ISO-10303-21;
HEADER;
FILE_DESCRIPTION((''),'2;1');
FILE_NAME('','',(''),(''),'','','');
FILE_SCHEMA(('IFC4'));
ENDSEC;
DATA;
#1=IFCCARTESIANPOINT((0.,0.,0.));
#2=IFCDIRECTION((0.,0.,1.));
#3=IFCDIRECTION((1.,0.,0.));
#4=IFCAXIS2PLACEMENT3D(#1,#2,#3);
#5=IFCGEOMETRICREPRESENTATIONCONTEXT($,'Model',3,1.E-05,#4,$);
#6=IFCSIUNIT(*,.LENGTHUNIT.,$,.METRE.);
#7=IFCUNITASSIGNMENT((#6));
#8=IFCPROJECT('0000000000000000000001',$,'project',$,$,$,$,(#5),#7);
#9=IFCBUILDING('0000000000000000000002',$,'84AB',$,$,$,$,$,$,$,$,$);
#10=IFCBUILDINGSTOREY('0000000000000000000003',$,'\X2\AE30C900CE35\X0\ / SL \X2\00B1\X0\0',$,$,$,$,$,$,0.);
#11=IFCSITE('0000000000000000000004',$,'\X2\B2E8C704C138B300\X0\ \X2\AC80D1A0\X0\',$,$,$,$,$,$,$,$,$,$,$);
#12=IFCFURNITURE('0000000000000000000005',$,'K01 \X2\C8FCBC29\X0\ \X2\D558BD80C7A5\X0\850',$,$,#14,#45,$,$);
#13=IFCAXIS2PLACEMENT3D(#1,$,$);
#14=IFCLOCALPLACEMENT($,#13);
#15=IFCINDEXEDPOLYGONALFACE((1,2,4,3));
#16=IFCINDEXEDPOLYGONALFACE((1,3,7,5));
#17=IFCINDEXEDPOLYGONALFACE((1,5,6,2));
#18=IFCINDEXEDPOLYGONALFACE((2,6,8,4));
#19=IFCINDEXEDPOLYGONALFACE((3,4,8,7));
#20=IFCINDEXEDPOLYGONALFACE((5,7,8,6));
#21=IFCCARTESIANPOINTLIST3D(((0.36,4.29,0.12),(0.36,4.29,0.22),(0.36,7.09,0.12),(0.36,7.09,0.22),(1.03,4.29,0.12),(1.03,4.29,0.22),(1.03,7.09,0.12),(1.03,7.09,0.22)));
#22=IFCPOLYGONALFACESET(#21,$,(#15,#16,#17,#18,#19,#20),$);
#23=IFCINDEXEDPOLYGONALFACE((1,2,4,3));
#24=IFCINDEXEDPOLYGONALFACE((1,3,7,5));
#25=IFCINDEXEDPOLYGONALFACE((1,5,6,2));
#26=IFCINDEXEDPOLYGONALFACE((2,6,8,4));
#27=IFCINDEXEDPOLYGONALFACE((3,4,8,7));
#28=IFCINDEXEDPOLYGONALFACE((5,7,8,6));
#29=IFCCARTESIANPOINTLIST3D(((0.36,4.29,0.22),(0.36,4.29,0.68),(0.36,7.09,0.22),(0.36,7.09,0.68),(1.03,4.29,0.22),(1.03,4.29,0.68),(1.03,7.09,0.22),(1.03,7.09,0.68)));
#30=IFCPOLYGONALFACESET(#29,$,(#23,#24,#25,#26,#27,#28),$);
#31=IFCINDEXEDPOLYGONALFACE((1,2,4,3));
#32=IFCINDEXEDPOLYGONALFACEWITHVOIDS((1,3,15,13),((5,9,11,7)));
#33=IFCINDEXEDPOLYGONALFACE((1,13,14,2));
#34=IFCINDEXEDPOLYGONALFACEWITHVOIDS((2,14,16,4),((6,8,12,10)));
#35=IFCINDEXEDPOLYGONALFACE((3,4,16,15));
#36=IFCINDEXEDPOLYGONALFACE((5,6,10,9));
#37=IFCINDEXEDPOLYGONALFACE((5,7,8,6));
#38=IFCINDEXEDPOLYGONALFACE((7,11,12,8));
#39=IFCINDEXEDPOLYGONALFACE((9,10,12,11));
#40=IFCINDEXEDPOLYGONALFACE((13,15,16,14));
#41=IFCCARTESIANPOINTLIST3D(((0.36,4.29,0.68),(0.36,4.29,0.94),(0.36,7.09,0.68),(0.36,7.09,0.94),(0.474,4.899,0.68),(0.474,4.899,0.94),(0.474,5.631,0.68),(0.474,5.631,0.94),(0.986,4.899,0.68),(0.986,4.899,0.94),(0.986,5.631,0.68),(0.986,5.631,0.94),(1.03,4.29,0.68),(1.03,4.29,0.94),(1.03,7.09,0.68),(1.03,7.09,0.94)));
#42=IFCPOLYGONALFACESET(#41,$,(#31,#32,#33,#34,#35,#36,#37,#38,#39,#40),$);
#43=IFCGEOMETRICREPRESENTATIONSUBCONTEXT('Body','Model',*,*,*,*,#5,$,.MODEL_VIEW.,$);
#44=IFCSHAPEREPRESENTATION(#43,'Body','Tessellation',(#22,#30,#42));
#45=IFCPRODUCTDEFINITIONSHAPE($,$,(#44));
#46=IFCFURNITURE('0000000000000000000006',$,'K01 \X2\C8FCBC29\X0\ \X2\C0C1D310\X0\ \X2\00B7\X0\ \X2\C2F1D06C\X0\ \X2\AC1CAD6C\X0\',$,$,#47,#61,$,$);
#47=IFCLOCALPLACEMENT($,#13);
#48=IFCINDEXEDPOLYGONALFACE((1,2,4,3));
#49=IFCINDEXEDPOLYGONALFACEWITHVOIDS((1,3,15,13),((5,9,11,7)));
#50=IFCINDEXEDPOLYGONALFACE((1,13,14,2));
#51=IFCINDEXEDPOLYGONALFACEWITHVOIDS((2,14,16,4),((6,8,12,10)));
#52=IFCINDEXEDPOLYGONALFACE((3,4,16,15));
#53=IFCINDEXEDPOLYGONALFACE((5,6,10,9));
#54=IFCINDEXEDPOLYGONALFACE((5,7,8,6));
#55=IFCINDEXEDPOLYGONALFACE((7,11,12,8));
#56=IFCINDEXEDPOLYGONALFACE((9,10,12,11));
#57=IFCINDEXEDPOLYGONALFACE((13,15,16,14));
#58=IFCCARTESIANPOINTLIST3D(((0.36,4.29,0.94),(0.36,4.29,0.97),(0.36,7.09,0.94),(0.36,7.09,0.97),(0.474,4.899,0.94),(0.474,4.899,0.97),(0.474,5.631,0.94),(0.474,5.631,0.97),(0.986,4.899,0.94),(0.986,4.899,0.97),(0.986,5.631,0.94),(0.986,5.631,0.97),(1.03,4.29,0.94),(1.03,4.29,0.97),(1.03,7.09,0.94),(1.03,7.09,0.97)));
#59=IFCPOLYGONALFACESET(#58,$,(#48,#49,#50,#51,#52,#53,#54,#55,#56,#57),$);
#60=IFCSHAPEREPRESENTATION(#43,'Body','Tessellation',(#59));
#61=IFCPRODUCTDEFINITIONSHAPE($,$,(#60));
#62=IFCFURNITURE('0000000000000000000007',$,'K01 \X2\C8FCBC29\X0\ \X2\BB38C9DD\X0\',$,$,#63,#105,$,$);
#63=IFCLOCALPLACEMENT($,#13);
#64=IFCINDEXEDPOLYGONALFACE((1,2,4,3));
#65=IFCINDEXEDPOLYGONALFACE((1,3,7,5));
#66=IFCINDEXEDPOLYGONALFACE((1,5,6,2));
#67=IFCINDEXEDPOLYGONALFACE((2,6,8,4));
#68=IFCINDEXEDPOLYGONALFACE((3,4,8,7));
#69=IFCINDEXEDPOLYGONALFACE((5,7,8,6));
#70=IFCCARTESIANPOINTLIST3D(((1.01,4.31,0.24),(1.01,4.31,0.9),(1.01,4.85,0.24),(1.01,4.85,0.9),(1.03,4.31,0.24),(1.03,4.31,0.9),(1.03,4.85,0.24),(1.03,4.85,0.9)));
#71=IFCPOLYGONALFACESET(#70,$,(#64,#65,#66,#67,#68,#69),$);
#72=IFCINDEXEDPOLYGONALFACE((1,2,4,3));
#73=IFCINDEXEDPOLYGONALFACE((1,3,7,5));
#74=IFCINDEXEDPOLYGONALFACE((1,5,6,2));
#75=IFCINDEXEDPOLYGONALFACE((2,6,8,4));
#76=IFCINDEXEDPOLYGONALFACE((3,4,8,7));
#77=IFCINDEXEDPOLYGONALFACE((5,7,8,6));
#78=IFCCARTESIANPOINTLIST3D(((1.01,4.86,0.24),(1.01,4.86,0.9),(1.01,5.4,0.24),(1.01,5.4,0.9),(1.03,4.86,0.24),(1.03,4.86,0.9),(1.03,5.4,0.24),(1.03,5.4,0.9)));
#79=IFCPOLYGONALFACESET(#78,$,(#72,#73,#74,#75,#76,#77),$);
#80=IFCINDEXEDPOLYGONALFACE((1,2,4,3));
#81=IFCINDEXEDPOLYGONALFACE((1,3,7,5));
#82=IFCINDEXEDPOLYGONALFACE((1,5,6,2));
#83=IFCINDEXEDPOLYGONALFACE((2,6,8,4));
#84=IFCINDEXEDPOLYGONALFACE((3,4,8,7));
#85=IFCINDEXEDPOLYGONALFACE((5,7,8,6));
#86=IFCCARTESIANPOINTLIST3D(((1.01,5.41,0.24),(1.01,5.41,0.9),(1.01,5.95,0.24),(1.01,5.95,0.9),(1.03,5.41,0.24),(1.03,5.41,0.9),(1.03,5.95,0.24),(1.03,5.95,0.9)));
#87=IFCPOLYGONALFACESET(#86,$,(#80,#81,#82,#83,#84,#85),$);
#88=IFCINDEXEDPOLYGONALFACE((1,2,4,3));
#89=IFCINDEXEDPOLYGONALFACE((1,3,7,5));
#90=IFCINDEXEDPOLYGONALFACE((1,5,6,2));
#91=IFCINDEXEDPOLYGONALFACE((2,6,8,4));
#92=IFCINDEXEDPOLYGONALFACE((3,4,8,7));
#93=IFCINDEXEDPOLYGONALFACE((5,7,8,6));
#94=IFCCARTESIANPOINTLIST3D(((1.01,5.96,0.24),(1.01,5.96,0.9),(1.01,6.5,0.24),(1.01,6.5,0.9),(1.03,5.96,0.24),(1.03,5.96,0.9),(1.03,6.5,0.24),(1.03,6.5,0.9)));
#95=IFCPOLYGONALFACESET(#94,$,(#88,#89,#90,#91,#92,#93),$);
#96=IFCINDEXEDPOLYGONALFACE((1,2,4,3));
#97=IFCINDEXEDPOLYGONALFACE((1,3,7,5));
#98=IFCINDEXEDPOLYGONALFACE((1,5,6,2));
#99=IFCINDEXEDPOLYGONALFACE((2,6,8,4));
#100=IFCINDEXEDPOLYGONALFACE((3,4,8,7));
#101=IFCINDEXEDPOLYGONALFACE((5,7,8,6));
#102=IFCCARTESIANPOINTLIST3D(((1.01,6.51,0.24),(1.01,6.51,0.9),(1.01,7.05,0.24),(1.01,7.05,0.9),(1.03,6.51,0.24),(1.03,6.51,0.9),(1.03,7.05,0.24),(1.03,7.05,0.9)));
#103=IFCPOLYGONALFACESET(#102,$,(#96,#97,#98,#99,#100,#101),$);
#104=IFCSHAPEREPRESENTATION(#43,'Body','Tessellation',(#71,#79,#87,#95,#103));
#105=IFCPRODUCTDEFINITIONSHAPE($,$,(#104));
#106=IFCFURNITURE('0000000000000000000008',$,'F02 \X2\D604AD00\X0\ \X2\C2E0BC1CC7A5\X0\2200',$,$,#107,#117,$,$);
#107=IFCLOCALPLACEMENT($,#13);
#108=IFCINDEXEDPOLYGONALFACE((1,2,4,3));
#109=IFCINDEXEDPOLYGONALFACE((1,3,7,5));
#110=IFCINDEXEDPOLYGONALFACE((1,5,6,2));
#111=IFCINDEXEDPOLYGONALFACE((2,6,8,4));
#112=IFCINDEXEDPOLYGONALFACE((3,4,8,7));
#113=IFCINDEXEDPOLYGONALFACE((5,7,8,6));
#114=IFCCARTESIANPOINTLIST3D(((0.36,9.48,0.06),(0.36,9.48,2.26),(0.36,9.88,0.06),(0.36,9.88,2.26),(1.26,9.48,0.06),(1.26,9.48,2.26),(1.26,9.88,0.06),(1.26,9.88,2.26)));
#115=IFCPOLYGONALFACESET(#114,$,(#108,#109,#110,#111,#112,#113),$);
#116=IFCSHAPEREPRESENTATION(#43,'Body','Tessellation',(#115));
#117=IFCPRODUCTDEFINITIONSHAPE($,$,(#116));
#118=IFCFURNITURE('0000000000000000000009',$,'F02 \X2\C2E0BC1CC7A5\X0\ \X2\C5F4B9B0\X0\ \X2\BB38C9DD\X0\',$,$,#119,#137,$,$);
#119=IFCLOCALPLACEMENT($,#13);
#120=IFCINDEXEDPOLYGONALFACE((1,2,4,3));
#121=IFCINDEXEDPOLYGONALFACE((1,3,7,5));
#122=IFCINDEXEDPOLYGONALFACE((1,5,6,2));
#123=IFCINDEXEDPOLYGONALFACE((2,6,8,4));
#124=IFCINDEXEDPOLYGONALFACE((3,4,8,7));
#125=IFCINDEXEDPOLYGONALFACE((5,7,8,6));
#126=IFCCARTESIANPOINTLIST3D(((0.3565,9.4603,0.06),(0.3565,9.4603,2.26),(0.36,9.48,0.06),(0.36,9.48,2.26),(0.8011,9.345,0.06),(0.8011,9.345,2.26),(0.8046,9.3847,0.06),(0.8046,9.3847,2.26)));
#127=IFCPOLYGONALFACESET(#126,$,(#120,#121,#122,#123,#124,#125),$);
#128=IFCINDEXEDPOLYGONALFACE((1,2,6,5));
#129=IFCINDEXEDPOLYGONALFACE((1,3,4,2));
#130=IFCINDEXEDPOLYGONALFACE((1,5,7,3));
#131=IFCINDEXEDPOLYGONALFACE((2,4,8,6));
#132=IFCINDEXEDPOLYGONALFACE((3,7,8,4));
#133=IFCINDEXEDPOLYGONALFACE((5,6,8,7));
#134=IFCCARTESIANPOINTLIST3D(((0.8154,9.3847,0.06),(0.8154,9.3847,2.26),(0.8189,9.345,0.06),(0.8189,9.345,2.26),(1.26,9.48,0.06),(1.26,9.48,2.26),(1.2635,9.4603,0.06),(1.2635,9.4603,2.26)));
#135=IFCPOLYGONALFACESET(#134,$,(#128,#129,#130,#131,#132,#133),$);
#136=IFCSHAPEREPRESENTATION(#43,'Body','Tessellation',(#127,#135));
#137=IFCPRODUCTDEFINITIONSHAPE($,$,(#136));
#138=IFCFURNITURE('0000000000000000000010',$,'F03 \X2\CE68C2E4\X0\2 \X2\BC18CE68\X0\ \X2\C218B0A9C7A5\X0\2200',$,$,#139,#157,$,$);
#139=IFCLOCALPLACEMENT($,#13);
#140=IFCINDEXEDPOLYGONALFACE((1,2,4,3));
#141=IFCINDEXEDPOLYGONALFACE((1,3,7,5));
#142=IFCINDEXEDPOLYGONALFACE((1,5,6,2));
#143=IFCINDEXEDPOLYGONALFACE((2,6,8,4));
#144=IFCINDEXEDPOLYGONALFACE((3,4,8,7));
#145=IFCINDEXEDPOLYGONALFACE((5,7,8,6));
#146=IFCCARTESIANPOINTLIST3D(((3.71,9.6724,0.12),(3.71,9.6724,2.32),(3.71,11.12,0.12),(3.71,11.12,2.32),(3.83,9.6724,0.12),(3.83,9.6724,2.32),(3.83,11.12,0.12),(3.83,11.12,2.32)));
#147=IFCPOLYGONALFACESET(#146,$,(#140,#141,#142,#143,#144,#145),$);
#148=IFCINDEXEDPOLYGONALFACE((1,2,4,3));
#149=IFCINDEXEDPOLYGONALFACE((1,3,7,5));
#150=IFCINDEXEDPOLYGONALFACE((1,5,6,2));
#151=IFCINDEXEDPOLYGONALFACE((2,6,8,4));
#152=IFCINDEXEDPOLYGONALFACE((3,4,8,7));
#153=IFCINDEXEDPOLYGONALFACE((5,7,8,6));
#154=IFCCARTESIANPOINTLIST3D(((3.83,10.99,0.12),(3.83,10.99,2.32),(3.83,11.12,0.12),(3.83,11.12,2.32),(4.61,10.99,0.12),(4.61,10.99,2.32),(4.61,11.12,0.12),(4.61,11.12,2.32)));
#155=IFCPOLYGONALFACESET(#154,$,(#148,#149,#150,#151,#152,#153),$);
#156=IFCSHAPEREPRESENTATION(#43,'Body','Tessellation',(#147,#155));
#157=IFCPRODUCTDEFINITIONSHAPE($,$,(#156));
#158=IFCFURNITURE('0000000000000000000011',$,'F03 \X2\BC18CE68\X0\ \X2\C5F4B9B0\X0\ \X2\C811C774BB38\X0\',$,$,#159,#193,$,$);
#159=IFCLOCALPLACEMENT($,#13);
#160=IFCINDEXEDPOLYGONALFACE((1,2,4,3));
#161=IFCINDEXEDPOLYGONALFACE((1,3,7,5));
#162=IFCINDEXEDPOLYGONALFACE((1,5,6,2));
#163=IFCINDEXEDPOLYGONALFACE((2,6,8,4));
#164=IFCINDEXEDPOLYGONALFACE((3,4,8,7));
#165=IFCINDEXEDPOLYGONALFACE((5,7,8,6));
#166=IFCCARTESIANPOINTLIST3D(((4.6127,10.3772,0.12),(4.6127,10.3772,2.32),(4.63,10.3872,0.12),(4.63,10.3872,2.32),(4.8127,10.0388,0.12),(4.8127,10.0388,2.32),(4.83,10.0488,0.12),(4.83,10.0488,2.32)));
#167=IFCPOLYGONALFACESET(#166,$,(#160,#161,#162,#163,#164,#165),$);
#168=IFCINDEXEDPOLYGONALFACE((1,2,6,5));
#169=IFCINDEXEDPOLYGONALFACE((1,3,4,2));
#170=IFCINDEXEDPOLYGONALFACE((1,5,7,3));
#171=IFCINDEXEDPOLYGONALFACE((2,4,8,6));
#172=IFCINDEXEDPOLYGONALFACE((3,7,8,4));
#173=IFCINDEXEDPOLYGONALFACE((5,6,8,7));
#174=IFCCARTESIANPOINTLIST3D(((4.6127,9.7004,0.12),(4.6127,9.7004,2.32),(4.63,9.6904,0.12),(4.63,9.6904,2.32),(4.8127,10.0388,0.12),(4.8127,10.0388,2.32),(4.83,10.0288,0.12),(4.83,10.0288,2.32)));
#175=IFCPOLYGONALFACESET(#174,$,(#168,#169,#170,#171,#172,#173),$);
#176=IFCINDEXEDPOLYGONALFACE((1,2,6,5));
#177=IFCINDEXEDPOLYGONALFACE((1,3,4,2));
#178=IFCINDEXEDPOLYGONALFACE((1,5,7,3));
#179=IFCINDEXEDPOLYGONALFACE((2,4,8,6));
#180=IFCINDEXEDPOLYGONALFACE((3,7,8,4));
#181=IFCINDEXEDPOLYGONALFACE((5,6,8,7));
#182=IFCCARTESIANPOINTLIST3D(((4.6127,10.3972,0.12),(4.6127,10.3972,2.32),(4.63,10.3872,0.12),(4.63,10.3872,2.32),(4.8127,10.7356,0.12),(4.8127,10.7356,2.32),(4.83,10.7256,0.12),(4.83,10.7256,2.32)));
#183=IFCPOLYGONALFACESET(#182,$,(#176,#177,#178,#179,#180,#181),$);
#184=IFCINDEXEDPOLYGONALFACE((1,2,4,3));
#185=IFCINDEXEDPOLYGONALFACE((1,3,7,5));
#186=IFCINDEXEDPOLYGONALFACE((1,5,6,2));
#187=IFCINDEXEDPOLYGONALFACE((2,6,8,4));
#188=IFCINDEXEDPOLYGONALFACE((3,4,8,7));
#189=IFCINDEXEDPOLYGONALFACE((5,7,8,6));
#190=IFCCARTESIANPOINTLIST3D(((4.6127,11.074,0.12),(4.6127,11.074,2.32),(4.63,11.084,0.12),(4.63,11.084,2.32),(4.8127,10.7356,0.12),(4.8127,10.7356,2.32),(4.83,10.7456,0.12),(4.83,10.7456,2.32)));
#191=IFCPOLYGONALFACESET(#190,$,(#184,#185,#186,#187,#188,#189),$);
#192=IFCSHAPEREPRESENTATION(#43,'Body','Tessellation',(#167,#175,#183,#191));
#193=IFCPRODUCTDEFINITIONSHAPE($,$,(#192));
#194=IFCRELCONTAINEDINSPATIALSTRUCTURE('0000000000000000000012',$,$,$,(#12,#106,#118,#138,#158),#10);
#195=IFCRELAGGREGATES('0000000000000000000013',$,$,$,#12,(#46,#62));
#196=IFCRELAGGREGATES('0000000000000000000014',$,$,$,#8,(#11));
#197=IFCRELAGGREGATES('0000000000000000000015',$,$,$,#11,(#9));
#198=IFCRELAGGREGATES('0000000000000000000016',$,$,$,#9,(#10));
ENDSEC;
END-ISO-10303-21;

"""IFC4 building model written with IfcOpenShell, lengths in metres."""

from ifc_helpers import new_model, si_unit, frame, origin_with_axes, place, context, subcontext, project, spatial, polyline, outline, extrude, element, aggregate, save


model = new_model("IFC4")

# Units and contexts
model_context = context("Model", 3, precision=1e-05, world=origin_with_axes())
body_context = subcontext(model_context, "Body", "Model", "MODEL_VIEW")
ifc_project = project(units=[si_unit("LENGTHUNIT", "METRE")], contexts=[model_context])

# Site, building, storey
site = spatial("IfcSite", under=ifc_project, Name="단위세대 검토")
building = spatial("IfcBuilding", under=site, Name="84AB")
storey = spatial("IfcBuildingStorey", under=building, Name="기준층 / SL ±0", Elevation=0.0)

# Furniture
furniture_1_placement = place(None, origin_with_axes())
furniture_1 = element("IfcFurniture", 1, at=furniture_1_placement, inside=storey, Name="K01 주방 하부장850", context=body_context, shape_type="SweptSolid", body=[
    extrude(outline(polyline([(1.03, 4.29), (1.03, 7.09), (0.36, 7.09), (0.36, 4.29), (1.03, 4.29)])), frame((0.0, 0.0, 0.12)), (0.0, 0.0, 1.0), 0.1),
    extrude(outline(polyline([(1.03, 4.29), (1.03, 7.09), (0.36, 7.09), (0.36, 4.29), (1.03, 4.29)])), frame((0.0, 0.0, 0.22)), (0.0, 0.0, 1.0), 0.46),
    extrude(outline(polyline([(0.36, 4.29), (0.36, 7.09), (1.03, 7.09), (1.03, 4.29), (0.36, 4.29)]), holes=[polyline([(0.986, 5.631), (0.474, 5.631), (0.474, 4.899), (0.986, 4.899), (0.986, 5.631)])]), frame((0.0, 0.0, 0.68)), (0.0, 0.0, 1.0), 0.26),
])
furniture_2_placement = place(furniture_1_placement, origin_with_axes())
furniture_2 = element("IfcFurniture", 2, at=furniture_2_placement, Name="K01 주방 상판 · 싱크 개구", context=body_context, shape_type="SweptSolid", body=[
    extrude(outline(polyline([(0.36, 4.29), (0.36, 7.09), (1.03, 7.09), (1.03, 4.29), (0.36, 4.29)]), holes=[polyline([(0.986, 5.631), (0.474, 5.631), (0.474, 4.899), (0.986, 4.899), (0.986, 5.631)])]), frame((0.0, 0.0, 0.94)), (0.0, 0.0, 1.0), 0.03),
])
furniture_3_placement = place(furniture_1_placement, origin_with_axes())
furniture_3 = element("IfcFurniture", 3, at=furniture_3_placement, Name="K01 주방 문짝", context=body_context, shape_type="SweptSolid", body=[
    extrude(outline(polyline([(1.03, 4.31), (1.03, 4.85), (1.01, 4.85), (1.01, 4.31), (1.03, 4.31)])), frame((0.0, 0.0, 0.24)), (0.0, 0.0, 1.0), 0.66),
    extrude(outline(polyline([(1.03, 4.86), (1.03, 5.4), (1.01, 5.4), (1.01, 4.86), (1.03, 4.86)])), frame((0.0, 0.0, 0.24)), (0.0, 0.0, 1.0), 0.66),
    extrude(outline(polyline([(1.03, 5.41), (1.03, 5.95), (1.01, 5.95), (1.01, 5.41), (1.03, 5.41)])), frame((0.0, 0.0, 0.24)), (0.0, 0.0, 1.0), 0.66),
    extrude(outline(polyline([(1.03, 5.96), (1.03, 6.5), (1.01, 6.5), (1.01, 5.96), (1.03, 5.96)])), frame((0.0, 0.0, 0.24)), (0.0, 0.0, 1.0), 0.66),
    extrude(outline(polyline([(1.03, 6.51), (1.03, 7.05), (1.01, 7.05), (1.01, 6.51), (1.03, 6.51)])), frame((0.0, 0.0, 0.24)), (0.0, 0.0, 1.0), 0.66),
])
aggregate(furniture_1, [furniture_2, furniture_3])
furniture_4_placement = place(None, origin_with_axes())
element("IfcFurniture", 4, at=furniture_4_placement, inside=storey, Name="F02 현관 신발장2200", context=body_context, shape_type="SweptSolid", body=[
    extrude(outline(polyline([(1.26, 9.48), (1.26, 9.88), (0.36, 9.88), (0.36, 9.48), (1.26, 9.48)])), frame((0.0, 0.0, 0.06)), (0.0, 0.0, 1.0), 2.2),
])
furniture_5_placement = place(None, origin_with_axes())
element("IfcFurniture", 5, at=furniture_5_placement, inside=storey, Name="F02 신발장 열린 문짝", context=body_context, shape_type="SweptSolid", body=[
    extrude(outline(polyline([(0.36, 9.48), (0.3565, 9.4603), (0.8011, 9.345), (0.8046, 9.3847), (0.36, 9.48)])), frame((0.0, 0.0, 0.06)), (0.0, 0.0, 1.0), 2.2),
    extrude(outline(polyline([(1.26, 9.48), (1.2635, 9.4603), (0.8189, 9.345), (0.8154, 9.3847), (1.26, 9.48)])), frame((0.0, 0.0, 0.06)), (0.0, 0.0, 1.0), 2.2),
])
furniture_6_placement = place(None, origin_with_axes())
element("IfcFurniture", 6, at=furniture_6_placement, inside=storey, Name="F03 침실2 반침 수납장2200", context=body_context, shape_type="SweptSolid", body=[
    extrude(outline(polyline([(3.83, 9.6724), (3.83, 11.12), (3.71, 11.12), (3.71, 9.6724), (3.83, 9.6724)])), frame((0.0, 0.0, 0.12)), (0.0, 0.0, 1.0), 2.2),
    extrude(outline(polyline([(4.61, 10.99), (4.61, 11.12), (3.83, 11.12), (3.83, 10.99), (4.61, 10.99)])), frame((0.0, 0.0, 0.12)), (0.0, 0.0, 1.0), 2.2),
])
furniture_7_placement = place(None, origin_with_axes())
element("IfcFurniture", 7, at=furniture_7_placement, inside=storey, Name="F03 반침 열린 접이문", context=body_context, shape_type="SweptSolid", body=[
    extrude(outline(polyline([(4.6127, 10.3772), (4.8127, 10.0388), (4.83, 10.0488), (4.63, 10.3872), (4.6127, 10.3772)])), frame((0.0, 0.0, 0.12)), (0.0, 0.0, 1.0), 2.2),
    extrude(outline(polyline([(4.6127, 9.7004), (4.8127, 10.0388), (4.83, 10.0288), (4.63, 9.6904), (4.6127, 9.7004)])), frame((0.0, 0.0, 0.12)), (0.0, 0.0, 1.0), 2.2),
    extrude(outline(polyline([(4.6127, 10.3972), (4.8127, 10.7356), (4.83, 10.7256), (4.63, 10.3872), (4.6127, 10.3972)])), frame((0.0, 0.0, 0.12)), (0.0, 0.0, 1.0), 2.2),
    extrude(outline(polyline([(4.6127, 11.074), (4.8127, 10.7356), (4.83, 10.7456), (4.63, 11.084), (4.6127, 11.074)])), frame((0.0, 0.0, 0.12)), (0.0, 0.0, 1.0), 2.2),
])

save(model, "model.ifc")
